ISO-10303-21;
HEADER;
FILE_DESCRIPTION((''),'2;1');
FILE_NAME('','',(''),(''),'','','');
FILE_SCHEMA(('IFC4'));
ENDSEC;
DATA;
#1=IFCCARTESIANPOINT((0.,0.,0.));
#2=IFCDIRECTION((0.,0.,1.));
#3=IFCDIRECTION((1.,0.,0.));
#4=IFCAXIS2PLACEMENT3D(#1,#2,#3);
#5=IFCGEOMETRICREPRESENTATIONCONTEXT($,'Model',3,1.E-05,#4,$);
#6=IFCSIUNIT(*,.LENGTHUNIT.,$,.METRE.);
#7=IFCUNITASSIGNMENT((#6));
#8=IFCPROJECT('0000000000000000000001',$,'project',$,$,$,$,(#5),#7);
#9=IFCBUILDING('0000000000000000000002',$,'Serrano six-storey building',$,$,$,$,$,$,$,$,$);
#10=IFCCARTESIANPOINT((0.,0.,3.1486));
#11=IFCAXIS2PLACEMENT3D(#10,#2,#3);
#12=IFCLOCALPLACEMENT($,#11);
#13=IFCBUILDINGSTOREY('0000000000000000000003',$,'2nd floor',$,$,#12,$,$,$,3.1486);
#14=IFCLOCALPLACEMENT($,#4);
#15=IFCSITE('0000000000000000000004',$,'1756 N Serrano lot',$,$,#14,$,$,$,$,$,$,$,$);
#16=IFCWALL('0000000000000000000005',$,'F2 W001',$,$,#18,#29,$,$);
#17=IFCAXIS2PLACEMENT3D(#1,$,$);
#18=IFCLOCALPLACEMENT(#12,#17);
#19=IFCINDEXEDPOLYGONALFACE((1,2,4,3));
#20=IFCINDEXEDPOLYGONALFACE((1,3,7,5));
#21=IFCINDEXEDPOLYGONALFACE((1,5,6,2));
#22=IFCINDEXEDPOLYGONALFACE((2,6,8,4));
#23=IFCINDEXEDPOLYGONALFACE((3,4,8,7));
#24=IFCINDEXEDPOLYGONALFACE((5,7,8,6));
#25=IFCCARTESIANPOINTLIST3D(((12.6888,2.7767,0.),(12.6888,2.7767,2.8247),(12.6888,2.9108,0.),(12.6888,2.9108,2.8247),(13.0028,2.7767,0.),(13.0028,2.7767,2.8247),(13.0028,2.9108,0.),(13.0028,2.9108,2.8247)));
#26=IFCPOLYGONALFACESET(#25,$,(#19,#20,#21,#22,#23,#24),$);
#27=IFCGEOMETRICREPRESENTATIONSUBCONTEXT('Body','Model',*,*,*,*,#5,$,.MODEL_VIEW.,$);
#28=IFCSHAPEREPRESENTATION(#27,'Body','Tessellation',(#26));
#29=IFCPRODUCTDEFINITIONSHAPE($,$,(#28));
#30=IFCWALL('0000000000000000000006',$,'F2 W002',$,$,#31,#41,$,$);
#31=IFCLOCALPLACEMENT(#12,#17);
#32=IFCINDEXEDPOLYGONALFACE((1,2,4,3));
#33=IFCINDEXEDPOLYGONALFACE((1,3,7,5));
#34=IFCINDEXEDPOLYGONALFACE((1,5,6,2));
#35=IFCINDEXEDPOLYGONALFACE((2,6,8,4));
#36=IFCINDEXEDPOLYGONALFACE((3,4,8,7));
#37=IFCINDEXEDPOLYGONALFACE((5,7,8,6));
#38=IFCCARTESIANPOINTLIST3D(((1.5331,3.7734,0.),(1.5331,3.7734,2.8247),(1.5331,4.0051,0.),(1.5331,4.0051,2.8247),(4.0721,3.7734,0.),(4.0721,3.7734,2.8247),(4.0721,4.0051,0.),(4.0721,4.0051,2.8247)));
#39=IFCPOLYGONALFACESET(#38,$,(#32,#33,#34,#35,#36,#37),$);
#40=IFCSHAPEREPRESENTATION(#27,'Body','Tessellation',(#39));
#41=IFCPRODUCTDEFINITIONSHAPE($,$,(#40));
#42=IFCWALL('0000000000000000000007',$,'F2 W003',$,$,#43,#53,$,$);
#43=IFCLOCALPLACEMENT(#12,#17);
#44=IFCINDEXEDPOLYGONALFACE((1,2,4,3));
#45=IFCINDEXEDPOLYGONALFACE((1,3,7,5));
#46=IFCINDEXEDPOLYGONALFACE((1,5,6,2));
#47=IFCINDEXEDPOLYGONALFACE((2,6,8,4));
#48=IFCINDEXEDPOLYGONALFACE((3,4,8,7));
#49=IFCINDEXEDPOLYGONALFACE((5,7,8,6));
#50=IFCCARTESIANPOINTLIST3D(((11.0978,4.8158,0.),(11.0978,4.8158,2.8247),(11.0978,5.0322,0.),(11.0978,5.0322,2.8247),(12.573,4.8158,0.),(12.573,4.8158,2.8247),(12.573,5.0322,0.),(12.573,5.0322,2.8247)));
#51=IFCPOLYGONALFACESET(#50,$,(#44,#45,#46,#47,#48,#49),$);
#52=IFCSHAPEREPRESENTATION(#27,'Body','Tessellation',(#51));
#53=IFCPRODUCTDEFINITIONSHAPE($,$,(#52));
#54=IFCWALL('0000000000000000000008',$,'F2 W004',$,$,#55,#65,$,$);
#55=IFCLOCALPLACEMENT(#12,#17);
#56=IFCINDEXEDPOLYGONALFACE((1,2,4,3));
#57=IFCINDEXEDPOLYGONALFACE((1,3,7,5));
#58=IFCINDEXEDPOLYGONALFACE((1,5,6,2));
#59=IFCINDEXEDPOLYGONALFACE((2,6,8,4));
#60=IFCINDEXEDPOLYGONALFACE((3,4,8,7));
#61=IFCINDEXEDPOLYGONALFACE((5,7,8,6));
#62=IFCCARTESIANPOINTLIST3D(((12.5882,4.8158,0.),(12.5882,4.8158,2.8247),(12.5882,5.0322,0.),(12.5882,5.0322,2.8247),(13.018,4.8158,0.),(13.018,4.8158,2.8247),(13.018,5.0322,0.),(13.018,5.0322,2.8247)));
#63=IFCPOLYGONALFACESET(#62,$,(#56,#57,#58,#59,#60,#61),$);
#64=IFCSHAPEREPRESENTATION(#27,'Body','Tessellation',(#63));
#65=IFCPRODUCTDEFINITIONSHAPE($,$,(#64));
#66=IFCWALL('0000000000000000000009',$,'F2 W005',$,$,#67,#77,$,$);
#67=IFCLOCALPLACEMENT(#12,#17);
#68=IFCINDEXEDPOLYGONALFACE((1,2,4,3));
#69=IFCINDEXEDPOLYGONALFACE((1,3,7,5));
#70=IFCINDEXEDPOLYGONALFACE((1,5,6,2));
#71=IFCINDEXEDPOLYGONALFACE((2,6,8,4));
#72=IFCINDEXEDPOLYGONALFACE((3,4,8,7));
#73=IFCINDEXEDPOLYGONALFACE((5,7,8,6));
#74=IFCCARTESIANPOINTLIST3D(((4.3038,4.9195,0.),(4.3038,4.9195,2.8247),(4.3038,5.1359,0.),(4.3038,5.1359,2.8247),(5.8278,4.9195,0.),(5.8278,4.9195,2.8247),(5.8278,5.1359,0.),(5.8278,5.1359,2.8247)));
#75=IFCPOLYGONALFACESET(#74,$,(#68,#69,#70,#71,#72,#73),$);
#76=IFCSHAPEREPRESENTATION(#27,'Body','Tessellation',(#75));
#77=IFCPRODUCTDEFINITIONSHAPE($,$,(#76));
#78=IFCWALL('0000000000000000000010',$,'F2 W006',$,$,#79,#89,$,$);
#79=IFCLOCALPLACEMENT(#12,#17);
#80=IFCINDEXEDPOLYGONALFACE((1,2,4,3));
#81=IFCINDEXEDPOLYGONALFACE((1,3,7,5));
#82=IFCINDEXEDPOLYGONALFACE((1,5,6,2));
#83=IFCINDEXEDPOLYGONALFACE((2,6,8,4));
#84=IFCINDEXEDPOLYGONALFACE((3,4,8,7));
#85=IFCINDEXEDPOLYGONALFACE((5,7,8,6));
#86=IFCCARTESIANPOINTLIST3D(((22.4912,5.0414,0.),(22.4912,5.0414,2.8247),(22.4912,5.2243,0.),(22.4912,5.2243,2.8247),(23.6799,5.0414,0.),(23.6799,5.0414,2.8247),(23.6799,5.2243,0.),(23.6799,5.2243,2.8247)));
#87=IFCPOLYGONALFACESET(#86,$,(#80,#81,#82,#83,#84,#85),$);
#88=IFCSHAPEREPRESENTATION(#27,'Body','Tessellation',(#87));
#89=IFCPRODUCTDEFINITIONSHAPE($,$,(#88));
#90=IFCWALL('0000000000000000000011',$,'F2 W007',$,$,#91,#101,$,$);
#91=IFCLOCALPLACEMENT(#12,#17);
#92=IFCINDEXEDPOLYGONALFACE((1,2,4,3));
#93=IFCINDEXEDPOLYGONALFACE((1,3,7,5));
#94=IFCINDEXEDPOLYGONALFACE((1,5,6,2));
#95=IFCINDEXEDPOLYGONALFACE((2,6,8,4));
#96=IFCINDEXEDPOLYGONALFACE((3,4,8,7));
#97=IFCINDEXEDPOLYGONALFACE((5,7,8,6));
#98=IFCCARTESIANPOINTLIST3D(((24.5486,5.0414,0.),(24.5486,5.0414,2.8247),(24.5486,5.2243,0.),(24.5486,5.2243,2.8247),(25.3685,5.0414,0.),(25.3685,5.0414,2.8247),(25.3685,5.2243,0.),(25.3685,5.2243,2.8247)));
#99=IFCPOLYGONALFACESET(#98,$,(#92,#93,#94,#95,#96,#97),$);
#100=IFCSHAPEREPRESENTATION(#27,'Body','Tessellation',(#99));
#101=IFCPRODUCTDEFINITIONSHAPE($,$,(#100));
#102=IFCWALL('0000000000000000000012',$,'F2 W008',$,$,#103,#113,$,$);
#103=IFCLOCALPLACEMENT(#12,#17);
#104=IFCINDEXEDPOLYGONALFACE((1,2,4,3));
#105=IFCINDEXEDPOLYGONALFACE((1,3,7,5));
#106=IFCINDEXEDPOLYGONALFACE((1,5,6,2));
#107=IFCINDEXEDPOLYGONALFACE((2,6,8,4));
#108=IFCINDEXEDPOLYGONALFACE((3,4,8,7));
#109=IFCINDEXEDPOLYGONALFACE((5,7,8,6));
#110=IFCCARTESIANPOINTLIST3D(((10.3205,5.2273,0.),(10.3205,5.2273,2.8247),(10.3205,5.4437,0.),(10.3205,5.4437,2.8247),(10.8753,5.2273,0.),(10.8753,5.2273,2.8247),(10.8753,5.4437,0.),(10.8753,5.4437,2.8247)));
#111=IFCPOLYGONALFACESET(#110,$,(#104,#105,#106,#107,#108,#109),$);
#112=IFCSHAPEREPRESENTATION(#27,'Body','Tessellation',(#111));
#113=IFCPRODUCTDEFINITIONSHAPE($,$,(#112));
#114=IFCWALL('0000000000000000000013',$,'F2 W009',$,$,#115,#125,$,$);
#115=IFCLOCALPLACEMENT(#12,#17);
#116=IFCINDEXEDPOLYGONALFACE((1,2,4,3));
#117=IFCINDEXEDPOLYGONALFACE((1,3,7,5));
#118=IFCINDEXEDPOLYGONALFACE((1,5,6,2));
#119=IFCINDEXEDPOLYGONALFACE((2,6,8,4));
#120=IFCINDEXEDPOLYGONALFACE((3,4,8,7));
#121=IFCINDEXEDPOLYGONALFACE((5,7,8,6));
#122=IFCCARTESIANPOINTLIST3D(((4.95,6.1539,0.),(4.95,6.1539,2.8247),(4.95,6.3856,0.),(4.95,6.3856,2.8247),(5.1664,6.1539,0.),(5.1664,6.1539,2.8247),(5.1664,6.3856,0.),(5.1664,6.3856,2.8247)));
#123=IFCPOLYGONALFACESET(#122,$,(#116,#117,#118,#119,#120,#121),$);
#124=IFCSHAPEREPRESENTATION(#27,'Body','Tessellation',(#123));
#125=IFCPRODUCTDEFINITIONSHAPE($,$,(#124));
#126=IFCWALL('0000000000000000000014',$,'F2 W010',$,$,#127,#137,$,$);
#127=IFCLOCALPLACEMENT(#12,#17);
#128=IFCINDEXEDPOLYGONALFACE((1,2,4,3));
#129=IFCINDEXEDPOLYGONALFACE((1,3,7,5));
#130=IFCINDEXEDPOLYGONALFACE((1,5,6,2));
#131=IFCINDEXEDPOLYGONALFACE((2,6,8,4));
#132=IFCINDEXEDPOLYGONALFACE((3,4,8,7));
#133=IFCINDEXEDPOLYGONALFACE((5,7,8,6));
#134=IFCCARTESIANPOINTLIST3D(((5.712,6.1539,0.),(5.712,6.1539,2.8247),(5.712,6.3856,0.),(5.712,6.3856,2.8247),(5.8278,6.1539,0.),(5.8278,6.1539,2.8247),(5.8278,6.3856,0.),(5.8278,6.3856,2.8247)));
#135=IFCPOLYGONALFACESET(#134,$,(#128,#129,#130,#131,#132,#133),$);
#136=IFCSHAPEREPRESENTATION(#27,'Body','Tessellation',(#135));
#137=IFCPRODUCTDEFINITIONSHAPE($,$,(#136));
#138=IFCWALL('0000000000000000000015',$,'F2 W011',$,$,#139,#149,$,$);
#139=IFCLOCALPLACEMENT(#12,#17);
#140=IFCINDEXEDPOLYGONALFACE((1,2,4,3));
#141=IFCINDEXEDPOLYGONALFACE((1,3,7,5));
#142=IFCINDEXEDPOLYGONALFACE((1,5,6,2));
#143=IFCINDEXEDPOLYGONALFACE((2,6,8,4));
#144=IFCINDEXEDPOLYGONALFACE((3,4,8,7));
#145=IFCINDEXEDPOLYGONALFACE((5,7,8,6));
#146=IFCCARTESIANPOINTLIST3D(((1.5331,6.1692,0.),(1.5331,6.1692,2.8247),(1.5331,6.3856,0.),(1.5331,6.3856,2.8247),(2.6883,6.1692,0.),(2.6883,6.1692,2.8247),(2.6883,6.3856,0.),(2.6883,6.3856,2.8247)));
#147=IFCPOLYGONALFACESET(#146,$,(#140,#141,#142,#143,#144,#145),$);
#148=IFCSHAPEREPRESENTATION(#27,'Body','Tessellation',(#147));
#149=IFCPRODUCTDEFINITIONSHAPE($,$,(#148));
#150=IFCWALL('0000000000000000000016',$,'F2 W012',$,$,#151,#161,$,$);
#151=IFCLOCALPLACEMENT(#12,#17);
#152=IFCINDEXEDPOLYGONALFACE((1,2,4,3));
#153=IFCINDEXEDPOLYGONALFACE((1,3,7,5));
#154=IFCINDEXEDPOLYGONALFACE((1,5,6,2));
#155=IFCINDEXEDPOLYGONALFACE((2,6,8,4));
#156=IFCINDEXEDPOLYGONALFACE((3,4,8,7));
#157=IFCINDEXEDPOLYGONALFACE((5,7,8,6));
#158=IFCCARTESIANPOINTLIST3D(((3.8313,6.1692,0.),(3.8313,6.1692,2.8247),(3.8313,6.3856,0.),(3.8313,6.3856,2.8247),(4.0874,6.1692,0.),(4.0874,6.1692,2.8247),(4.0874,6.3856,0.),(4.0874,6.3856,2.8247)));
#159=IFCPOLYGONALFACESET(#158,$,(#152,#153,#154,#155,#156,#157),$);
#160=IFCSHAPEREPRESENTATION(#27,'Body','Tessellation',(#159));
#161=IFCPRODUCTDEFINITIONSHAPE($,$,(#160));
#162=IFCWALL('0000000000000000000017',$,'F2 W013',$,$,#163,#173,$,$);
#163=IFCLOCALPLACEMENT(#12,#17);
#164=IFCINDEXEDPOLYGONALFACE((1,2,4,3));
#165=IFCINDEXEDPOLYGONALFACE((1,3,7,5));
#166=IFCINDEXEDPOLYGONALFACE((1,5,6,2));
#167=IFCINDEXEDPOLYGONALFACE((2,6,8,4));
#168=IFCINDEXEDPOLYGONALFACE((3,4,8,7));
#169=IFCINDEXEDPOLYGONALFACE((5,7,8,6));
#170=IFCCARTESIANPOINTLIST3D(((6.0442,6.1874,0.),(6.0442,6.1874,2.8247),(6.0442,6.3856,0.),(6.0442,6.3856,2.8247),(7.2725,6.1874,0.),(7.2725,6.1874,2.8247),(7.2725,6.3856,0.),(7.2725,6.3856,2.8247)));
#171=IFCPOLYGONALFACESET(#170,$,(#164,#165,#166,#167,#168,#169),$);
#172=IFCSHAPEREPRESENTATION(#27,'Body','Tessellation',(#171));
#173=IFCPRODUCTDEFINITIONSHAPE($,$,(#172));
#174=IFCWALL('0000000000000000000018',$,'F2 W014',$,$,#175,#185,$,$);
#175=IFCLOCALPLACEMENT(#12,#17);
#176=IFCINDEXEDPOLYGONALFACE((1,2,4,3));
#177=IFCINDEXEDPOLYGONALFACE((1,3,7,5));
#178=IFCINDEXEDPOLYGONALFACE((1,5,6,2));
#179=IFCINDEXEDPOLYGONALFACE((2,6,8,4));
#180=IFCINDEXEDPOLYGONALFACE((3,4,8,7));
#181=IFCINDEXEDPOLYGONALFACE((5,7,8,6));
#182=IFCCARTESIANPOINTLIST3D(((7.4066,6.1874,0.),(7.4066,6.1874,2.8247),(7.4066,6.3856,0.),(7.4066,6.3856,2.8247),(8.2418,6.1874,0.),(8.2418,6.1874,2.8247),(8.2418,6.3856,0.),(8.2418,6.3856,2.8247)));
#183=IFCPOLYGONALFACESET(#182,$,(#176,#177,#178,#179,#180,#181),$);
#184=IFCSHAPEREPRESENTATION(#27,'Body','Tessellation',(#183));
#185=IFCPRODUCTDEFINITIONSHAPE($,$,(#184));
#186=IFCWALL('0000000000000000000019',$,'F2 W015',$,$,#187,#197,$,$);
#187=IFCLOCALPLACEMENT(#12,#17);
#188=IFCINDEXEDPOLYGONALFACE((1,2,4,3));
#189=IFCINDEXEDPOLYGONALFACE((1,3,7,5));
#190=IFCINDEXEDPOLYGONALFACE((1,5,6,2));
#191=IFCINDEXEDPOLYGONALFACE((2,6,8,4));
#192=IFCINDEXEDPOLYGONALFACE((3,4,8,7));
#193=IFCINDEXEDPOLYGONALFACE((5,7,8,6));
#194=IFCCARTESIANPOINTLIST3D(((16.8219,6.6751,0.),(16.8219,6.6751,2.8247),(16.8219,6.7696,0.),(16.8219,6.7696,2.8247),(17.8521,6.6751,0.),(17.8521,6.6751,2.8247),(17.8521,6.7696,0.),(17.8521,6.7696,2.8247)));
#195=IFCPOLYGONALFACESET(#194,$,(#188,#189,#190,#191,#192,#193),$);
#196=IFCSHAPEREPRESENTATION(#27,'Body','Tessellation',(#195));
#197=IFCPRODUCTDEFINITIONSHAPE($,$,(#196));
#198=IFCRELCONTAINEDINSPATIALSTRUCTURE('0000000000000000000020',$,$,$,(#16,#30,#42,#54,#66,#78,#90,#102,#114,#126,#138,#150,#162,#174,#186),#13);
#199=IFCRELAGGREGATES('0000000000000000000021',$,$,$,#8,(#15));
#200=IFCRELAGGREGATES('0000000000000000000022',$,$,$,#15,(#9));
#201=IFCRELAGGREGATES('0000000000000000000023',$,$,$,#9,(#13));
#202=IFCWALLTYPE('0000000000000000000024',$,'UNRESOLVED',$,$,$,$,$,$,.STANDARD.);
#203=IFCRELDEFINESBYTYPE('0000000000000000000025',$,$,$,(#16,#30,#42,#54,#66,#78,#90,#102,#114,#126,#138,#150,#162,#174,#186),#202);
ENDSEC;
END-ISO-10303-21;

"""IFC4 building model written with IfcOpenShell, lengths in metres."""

from ifc_helpers import new_model, si_unit, frame, origin_with_axes, place, context, subcontext, project, spatial, polyline, outline, extrude, type_object, element, save


model = new_model("IFC4")

# Units and contexts
model_context = context("Model", 3, precision=1e-05, world=origin_with_axes())
body_context = subcontext(model_context, "Body", "Model", "MODEL_VIEW")
ifc_project = project(units=[si_unit("LENGTHUNIT", "METRE")], contexts=[model_context])

# Site, building, storey
site_placement = place(None, origin_with_axes())
site = spatial("IfcSite", under=ifc_project, at=site_placement, Name="1756 N Serrano lot")
building = spatial("IfcBuilding", under=site, Name="Serrano six-storey building")
storey_placement = place(None, frame((0.0, 0.0, 3.1486), z_axis=(0.0, 0.0, 1.0), x_axis=(1.0, 0.0, 0.0)))
storey = spatial("IfcBuildingStorey", under=building, at=storey_placement, Name="2nd floor", Elevation=3.1486)

# Walls
wall_type = type_object("IfcWallType", Name="UNRESOLVED", PredefinedType="STANDARD")
wall_1_placement = place(storey_placement, frame((0.0, 0.0, -3.1486), z_axis=(0.0, 0.0, 1.0), x_axis=(1.0, 0.0, 0.0)))
element("IfcWall", 1, at=wall_1_placement, inside=storey, type_object=wall_type, Name="F2 W001", context=body_context, shape_type="SweptSolid", body=[
    extrude(outline(polyline([(13.0028, 2.9108), (13.0028, 2.7767), (12.6888, 2.7767), (12.6888, 2.9108), (13.0028, 2.9108)])), frame((0.0, 0.0, 3.1486)), (0.0, 0.0, 1.0), 2.8247),
])
wall_2_placement = place(storey_placement, frame((0.0, 0.0, -3.1486), z_axis=(0.0, 0.0, 1.0), x_axis=(1.0, 0.0, 0.0)))
element("IfcWall", 2, at=wall_2_placement, inside=storey, type_object=wall_type, Name="F2 W002", context=body_context, shape_type="SweptSolid", body=[
    extrude(outline(polyline([(4.0721, 4.0051), (4.0721, 3.7734), (1.5331, 3.7734), (1.5331, 4.0051), (4.0721, 4.0051)])), frame((0.0, 0.0, 3.1486)), (0.0, 0.0, 1.0), 2.8247),
])
wall_3_placement = place(storey_placement, frame((0.0, 0.0, -3.1486), z_axis=(0.0, 0.0, 1.0), x_axis=(1.0, 0.0, 0.0)))
element("IfcWall", 3, at=wall_3_placement, inside=storey, type_object=wall_type, Name="F2 W003", context=body_context, shape_type="SweptSolid", body=[
    extrude(outline(polyline([(12.573, 5.0322), (12.573, 4.8158), (11.0978, 4.8158), (11.0978, 5.0322), (12.573, 5.0322)])), frame((0.0, 0.0, 3.1486)), (0.0, 0.0, 1.0), 2.8247),
])
wall_4_placement = place(storey_placement, frame((0.0, 0.0, -3.1486), z_axis=(0.0, 0.0, 1.0), x_axis=(1.0, 0.0, 0.0)))
element("IfcWall", 4, at=wall_4_placement, inside=storey, type_object=wall_type, Name="F2 W004", context=body_context, shape_type="SweptSolid", body=[
    extrude(outline(polyline([(13.018, 5.0322), (13.018, 4.8158), (12.5882, 4.8158), (12.5882, 5.0322), (13.018, 5.0322)])), frame((0.0, 0.0, 3.1486)), (0.0, 0.0, 1.0), 2.8247),
])
wall_5_placement = place(storey_placement, frame((0.0, 0.0, -3.1486), z_axis=(0.0, 0.0, 1.0), x_axis=(1.0, 0.0, 0.0)))
element("IfcWall", 5, at=wall_5_placement, inside=storey, type_object=wall_type, Name="F2 W005", context=body_context, shape_type="SweptSolid", body=[
    extrude(outline(polyline([(5.8278, 5.1359), (5.8278, 4.9195), (4.3038, 4.9195), (4.3038, 5.1359), (5.8278, 5.1359)])), frame((0.0, 0.0, 3.1486)), (0.0, 0.0, 1.0), 2.8247),
])
wall_6_placement = place(storey_placement, frame((0.0, 0.0, -3.1486), z_axis=(0.0, 0.0, 1.0), x_axis=(1.0, 0.0, 0.0)))
element("IfcWall", 6, at=wall_6_placement, inside=storey, type_object=wall_type, Name="F2 W006", context=body_context, shape_type="SweptSolid", body=[
    extrude(outline(polyline([(23.6799, 5.2243), (23.6799, 5.0414), (22.4912, 5.0414), (22.4912, 5.2243), (23.6799, 5.2243)])), frame((0.0, 0.0, 3.1486)), (0.0, 0.0, 1.0), 2.8247),
])
wall_7_placement = place(storey_placement, frame((0.0, 0.0, -3.1486), z_axis=(0.0, 0.0, 1.0), x_axis=(1.0, 0.0, 0.0)))
element("IfcWall", 7, at=wall_7_placement, inside=storey, type_object=wall_type, Name="F2 W007", context=body_context, shape_type="SweptSolid", body=[
    extrude(outline(polyline([(25.3685, 5.2243), (25.3685, 5.0414), (24.5486, 5.0414), (24.5486, 5.2243), (25.3685, 5.2243)])), frame((0.0, 0.0, 3.1486)), (0.0, 0.0, 1.0), 2.8247),
])
wall_8_placement = place(storey_placement, frame((0.0, 0.0, -3.1486), z_axis=(0.0, 0.0, 1.0), x_axis=(1.0, 0.0, 0.0)))
element("IfcWall", 8, at=wall_8_placement, inside=storey, type_object=wall_type, Name="F2 W008", context=body_context, shape_type="SweptSolid", body=[
    extrude(outline(polyline([(10.8753, 5.4437), (10.8753, 5.2273), (10.3205, 5.2273), (10.3205, 5.4437), (10.8753, 5.4437)])), frame((0.0, 0.0, 3.1486)), (0.0, 0.0, 1.0), 2.8247),
])
wall_9_placement = place(storey_placement, frame((0.0, 0.0, -3.1486), z_axis=(0.0, 0.0, 1.0), x_axis=(1.0, 0.0, 0.0)))
element("IfcWall", 9, at=wall_9_placement, inside=storey, type_object=wall_type, Name="F2 W009", context=body_context, shape_type="SweptSolid", body=[
    extrude(outline(polyline([(5.1664, 6.3856), (5.1664, 6.1539), (4.95, 6.1539), (4.95, 6.3856), (5.1664, 6.3856)])), frame((0.0, 0.0, 3.1486)), (0.0, 0.0, 1.0), 2.8247),
])
wall_10_placement = place(storey_placement, frame((0.0, 0.0, -3.1486), z_axis=(0.0, 0.0, 1.0), x_axis=(1.0, 0.0, 0.0)))
element("IfcWall", 10, at=wall_10_placement, inside=storey, type_object=wall_type, Name="F2 W010", context=body_context, shape_type="SweptSolid", body=[
    extrude(outline(polyline([(5.8278, 6.3856), (5.8278, 6.1539), (5.712, 6.1539), (5.712, 6.3856), (5.8278, 6.3856)])), frame((0.0, 0.0, 3.1486)), (0.0, 0.0, 1.0), 2.8247),
])
wall_11_placement = place(storey_placement, frame((0.0, 0.0, -3.1486), z_axis=(0.0, 0.0, 1.0), x_axis=(1.0, 0.0, 0.0)))
element("IfcWall", 11, at=wall_11_placement, inside=storey, type_object=wall_type, Name="F2 W011", context=body_context, shape_type="SweptSolid", body=[
    extrude(outline(polyline([(2.6883, 6.3856), (2.6883, 6.1692), (1.5331, 6.1692), (1.5331, 6.3856), (2.6883, 6.3856)])), frame((0.0, 0.0, 3.1486)), (0.0, 0.0, 1.0), 2.8247),
])
wall_12_placement = place(storey_placement, frame((0.0, 0.0, -3.1486), z_axis=(0.0, 0.0, 1.0), x_axis=(1.0, 0.0, 0.0)))
element("IfcWall", 12, at=wall_12_placement, inside=storey, type_object=wall_type, Name="F2 W012", context=body_context, shape_type="SweptSolid", body=[
    extrude(outline(polyline([(4.0874, 6.3856), (4.0874, 6.1692), (3.8313, 6.1692), (3.8313, 6.3856), (4.0874, 6.3856)])), frame((0.0, 0.0, 3.1486)), (0.0, 0.0, 1.0), 2.8247),
])
wall_13_placement = place(storey_placement, frame((0.0, 0.0, -3.1486), z_axis=(0.0, 0.0, 1.0), x_axis=(1.0, 0.0, 0.0)))
element("IfcWall", 13, at=wall_13_placement, inside=storey, type_object=wall_type, Name="F2 W013", context=body_context, shape_type="SweptSolid", body=[
    extrude(outline(polyline([(7.2725, 6.3856), (7.2725, 6.1874), (6.0442, 6.1874), (6.0442, 6.3856), (7.2725, 6.3856)])), frame((0.0, 0.0, 3.1486)), (0.0, 0.0, 1.0), 2.8247),
])
wall_14_placement = place(storey_placement, frame((0.0, 0.0, -3.1486), z_axis=(0.0, 0.0, 1.0), x_axis=(1.0, 0.0, 0.0)))
element("IfcWall", 14, at=wall_14_placement, inside=storey, type_object=wall_type, Name="F2 W014", context=body_context, shape_type="SweptSolid", body=[
    extrude(outline(polyline([(8.2418, 6.3856), (8.2418, 6.1874), (7.4066, 6.1874), (7.4066, 6.3856), (8.2418, 6.3856)])), frame((0.0, 0.0, 3.1486)), (0.0, 0.0, 1.0), 2.8247),
])
wall_15_placement = place(storey_placement, frame((0.0, 0.0, -3.1486), z_axis=(0.0, 0.0, 1.0), x_axis=(1.0, 0.0, 0.0)))
element("IfcWall", 15, at=wall_15_placement, inside=storey, type_object=wall_type, Name="F2 W015", context=body_context, shape_type="SweptSolid", body=[
    extrude(outline(polyline([(17.8521, 6.7696), (17.8521, 6.6751), (16.8219, 6.6751), (16.8219, 6.7696), (17.8521, 6.7696)])), frame((0.0, 0.0, 3.1486)), (0.0, 0.0, 1.0), 2.8247),
])

save(model, "model.ifc")
